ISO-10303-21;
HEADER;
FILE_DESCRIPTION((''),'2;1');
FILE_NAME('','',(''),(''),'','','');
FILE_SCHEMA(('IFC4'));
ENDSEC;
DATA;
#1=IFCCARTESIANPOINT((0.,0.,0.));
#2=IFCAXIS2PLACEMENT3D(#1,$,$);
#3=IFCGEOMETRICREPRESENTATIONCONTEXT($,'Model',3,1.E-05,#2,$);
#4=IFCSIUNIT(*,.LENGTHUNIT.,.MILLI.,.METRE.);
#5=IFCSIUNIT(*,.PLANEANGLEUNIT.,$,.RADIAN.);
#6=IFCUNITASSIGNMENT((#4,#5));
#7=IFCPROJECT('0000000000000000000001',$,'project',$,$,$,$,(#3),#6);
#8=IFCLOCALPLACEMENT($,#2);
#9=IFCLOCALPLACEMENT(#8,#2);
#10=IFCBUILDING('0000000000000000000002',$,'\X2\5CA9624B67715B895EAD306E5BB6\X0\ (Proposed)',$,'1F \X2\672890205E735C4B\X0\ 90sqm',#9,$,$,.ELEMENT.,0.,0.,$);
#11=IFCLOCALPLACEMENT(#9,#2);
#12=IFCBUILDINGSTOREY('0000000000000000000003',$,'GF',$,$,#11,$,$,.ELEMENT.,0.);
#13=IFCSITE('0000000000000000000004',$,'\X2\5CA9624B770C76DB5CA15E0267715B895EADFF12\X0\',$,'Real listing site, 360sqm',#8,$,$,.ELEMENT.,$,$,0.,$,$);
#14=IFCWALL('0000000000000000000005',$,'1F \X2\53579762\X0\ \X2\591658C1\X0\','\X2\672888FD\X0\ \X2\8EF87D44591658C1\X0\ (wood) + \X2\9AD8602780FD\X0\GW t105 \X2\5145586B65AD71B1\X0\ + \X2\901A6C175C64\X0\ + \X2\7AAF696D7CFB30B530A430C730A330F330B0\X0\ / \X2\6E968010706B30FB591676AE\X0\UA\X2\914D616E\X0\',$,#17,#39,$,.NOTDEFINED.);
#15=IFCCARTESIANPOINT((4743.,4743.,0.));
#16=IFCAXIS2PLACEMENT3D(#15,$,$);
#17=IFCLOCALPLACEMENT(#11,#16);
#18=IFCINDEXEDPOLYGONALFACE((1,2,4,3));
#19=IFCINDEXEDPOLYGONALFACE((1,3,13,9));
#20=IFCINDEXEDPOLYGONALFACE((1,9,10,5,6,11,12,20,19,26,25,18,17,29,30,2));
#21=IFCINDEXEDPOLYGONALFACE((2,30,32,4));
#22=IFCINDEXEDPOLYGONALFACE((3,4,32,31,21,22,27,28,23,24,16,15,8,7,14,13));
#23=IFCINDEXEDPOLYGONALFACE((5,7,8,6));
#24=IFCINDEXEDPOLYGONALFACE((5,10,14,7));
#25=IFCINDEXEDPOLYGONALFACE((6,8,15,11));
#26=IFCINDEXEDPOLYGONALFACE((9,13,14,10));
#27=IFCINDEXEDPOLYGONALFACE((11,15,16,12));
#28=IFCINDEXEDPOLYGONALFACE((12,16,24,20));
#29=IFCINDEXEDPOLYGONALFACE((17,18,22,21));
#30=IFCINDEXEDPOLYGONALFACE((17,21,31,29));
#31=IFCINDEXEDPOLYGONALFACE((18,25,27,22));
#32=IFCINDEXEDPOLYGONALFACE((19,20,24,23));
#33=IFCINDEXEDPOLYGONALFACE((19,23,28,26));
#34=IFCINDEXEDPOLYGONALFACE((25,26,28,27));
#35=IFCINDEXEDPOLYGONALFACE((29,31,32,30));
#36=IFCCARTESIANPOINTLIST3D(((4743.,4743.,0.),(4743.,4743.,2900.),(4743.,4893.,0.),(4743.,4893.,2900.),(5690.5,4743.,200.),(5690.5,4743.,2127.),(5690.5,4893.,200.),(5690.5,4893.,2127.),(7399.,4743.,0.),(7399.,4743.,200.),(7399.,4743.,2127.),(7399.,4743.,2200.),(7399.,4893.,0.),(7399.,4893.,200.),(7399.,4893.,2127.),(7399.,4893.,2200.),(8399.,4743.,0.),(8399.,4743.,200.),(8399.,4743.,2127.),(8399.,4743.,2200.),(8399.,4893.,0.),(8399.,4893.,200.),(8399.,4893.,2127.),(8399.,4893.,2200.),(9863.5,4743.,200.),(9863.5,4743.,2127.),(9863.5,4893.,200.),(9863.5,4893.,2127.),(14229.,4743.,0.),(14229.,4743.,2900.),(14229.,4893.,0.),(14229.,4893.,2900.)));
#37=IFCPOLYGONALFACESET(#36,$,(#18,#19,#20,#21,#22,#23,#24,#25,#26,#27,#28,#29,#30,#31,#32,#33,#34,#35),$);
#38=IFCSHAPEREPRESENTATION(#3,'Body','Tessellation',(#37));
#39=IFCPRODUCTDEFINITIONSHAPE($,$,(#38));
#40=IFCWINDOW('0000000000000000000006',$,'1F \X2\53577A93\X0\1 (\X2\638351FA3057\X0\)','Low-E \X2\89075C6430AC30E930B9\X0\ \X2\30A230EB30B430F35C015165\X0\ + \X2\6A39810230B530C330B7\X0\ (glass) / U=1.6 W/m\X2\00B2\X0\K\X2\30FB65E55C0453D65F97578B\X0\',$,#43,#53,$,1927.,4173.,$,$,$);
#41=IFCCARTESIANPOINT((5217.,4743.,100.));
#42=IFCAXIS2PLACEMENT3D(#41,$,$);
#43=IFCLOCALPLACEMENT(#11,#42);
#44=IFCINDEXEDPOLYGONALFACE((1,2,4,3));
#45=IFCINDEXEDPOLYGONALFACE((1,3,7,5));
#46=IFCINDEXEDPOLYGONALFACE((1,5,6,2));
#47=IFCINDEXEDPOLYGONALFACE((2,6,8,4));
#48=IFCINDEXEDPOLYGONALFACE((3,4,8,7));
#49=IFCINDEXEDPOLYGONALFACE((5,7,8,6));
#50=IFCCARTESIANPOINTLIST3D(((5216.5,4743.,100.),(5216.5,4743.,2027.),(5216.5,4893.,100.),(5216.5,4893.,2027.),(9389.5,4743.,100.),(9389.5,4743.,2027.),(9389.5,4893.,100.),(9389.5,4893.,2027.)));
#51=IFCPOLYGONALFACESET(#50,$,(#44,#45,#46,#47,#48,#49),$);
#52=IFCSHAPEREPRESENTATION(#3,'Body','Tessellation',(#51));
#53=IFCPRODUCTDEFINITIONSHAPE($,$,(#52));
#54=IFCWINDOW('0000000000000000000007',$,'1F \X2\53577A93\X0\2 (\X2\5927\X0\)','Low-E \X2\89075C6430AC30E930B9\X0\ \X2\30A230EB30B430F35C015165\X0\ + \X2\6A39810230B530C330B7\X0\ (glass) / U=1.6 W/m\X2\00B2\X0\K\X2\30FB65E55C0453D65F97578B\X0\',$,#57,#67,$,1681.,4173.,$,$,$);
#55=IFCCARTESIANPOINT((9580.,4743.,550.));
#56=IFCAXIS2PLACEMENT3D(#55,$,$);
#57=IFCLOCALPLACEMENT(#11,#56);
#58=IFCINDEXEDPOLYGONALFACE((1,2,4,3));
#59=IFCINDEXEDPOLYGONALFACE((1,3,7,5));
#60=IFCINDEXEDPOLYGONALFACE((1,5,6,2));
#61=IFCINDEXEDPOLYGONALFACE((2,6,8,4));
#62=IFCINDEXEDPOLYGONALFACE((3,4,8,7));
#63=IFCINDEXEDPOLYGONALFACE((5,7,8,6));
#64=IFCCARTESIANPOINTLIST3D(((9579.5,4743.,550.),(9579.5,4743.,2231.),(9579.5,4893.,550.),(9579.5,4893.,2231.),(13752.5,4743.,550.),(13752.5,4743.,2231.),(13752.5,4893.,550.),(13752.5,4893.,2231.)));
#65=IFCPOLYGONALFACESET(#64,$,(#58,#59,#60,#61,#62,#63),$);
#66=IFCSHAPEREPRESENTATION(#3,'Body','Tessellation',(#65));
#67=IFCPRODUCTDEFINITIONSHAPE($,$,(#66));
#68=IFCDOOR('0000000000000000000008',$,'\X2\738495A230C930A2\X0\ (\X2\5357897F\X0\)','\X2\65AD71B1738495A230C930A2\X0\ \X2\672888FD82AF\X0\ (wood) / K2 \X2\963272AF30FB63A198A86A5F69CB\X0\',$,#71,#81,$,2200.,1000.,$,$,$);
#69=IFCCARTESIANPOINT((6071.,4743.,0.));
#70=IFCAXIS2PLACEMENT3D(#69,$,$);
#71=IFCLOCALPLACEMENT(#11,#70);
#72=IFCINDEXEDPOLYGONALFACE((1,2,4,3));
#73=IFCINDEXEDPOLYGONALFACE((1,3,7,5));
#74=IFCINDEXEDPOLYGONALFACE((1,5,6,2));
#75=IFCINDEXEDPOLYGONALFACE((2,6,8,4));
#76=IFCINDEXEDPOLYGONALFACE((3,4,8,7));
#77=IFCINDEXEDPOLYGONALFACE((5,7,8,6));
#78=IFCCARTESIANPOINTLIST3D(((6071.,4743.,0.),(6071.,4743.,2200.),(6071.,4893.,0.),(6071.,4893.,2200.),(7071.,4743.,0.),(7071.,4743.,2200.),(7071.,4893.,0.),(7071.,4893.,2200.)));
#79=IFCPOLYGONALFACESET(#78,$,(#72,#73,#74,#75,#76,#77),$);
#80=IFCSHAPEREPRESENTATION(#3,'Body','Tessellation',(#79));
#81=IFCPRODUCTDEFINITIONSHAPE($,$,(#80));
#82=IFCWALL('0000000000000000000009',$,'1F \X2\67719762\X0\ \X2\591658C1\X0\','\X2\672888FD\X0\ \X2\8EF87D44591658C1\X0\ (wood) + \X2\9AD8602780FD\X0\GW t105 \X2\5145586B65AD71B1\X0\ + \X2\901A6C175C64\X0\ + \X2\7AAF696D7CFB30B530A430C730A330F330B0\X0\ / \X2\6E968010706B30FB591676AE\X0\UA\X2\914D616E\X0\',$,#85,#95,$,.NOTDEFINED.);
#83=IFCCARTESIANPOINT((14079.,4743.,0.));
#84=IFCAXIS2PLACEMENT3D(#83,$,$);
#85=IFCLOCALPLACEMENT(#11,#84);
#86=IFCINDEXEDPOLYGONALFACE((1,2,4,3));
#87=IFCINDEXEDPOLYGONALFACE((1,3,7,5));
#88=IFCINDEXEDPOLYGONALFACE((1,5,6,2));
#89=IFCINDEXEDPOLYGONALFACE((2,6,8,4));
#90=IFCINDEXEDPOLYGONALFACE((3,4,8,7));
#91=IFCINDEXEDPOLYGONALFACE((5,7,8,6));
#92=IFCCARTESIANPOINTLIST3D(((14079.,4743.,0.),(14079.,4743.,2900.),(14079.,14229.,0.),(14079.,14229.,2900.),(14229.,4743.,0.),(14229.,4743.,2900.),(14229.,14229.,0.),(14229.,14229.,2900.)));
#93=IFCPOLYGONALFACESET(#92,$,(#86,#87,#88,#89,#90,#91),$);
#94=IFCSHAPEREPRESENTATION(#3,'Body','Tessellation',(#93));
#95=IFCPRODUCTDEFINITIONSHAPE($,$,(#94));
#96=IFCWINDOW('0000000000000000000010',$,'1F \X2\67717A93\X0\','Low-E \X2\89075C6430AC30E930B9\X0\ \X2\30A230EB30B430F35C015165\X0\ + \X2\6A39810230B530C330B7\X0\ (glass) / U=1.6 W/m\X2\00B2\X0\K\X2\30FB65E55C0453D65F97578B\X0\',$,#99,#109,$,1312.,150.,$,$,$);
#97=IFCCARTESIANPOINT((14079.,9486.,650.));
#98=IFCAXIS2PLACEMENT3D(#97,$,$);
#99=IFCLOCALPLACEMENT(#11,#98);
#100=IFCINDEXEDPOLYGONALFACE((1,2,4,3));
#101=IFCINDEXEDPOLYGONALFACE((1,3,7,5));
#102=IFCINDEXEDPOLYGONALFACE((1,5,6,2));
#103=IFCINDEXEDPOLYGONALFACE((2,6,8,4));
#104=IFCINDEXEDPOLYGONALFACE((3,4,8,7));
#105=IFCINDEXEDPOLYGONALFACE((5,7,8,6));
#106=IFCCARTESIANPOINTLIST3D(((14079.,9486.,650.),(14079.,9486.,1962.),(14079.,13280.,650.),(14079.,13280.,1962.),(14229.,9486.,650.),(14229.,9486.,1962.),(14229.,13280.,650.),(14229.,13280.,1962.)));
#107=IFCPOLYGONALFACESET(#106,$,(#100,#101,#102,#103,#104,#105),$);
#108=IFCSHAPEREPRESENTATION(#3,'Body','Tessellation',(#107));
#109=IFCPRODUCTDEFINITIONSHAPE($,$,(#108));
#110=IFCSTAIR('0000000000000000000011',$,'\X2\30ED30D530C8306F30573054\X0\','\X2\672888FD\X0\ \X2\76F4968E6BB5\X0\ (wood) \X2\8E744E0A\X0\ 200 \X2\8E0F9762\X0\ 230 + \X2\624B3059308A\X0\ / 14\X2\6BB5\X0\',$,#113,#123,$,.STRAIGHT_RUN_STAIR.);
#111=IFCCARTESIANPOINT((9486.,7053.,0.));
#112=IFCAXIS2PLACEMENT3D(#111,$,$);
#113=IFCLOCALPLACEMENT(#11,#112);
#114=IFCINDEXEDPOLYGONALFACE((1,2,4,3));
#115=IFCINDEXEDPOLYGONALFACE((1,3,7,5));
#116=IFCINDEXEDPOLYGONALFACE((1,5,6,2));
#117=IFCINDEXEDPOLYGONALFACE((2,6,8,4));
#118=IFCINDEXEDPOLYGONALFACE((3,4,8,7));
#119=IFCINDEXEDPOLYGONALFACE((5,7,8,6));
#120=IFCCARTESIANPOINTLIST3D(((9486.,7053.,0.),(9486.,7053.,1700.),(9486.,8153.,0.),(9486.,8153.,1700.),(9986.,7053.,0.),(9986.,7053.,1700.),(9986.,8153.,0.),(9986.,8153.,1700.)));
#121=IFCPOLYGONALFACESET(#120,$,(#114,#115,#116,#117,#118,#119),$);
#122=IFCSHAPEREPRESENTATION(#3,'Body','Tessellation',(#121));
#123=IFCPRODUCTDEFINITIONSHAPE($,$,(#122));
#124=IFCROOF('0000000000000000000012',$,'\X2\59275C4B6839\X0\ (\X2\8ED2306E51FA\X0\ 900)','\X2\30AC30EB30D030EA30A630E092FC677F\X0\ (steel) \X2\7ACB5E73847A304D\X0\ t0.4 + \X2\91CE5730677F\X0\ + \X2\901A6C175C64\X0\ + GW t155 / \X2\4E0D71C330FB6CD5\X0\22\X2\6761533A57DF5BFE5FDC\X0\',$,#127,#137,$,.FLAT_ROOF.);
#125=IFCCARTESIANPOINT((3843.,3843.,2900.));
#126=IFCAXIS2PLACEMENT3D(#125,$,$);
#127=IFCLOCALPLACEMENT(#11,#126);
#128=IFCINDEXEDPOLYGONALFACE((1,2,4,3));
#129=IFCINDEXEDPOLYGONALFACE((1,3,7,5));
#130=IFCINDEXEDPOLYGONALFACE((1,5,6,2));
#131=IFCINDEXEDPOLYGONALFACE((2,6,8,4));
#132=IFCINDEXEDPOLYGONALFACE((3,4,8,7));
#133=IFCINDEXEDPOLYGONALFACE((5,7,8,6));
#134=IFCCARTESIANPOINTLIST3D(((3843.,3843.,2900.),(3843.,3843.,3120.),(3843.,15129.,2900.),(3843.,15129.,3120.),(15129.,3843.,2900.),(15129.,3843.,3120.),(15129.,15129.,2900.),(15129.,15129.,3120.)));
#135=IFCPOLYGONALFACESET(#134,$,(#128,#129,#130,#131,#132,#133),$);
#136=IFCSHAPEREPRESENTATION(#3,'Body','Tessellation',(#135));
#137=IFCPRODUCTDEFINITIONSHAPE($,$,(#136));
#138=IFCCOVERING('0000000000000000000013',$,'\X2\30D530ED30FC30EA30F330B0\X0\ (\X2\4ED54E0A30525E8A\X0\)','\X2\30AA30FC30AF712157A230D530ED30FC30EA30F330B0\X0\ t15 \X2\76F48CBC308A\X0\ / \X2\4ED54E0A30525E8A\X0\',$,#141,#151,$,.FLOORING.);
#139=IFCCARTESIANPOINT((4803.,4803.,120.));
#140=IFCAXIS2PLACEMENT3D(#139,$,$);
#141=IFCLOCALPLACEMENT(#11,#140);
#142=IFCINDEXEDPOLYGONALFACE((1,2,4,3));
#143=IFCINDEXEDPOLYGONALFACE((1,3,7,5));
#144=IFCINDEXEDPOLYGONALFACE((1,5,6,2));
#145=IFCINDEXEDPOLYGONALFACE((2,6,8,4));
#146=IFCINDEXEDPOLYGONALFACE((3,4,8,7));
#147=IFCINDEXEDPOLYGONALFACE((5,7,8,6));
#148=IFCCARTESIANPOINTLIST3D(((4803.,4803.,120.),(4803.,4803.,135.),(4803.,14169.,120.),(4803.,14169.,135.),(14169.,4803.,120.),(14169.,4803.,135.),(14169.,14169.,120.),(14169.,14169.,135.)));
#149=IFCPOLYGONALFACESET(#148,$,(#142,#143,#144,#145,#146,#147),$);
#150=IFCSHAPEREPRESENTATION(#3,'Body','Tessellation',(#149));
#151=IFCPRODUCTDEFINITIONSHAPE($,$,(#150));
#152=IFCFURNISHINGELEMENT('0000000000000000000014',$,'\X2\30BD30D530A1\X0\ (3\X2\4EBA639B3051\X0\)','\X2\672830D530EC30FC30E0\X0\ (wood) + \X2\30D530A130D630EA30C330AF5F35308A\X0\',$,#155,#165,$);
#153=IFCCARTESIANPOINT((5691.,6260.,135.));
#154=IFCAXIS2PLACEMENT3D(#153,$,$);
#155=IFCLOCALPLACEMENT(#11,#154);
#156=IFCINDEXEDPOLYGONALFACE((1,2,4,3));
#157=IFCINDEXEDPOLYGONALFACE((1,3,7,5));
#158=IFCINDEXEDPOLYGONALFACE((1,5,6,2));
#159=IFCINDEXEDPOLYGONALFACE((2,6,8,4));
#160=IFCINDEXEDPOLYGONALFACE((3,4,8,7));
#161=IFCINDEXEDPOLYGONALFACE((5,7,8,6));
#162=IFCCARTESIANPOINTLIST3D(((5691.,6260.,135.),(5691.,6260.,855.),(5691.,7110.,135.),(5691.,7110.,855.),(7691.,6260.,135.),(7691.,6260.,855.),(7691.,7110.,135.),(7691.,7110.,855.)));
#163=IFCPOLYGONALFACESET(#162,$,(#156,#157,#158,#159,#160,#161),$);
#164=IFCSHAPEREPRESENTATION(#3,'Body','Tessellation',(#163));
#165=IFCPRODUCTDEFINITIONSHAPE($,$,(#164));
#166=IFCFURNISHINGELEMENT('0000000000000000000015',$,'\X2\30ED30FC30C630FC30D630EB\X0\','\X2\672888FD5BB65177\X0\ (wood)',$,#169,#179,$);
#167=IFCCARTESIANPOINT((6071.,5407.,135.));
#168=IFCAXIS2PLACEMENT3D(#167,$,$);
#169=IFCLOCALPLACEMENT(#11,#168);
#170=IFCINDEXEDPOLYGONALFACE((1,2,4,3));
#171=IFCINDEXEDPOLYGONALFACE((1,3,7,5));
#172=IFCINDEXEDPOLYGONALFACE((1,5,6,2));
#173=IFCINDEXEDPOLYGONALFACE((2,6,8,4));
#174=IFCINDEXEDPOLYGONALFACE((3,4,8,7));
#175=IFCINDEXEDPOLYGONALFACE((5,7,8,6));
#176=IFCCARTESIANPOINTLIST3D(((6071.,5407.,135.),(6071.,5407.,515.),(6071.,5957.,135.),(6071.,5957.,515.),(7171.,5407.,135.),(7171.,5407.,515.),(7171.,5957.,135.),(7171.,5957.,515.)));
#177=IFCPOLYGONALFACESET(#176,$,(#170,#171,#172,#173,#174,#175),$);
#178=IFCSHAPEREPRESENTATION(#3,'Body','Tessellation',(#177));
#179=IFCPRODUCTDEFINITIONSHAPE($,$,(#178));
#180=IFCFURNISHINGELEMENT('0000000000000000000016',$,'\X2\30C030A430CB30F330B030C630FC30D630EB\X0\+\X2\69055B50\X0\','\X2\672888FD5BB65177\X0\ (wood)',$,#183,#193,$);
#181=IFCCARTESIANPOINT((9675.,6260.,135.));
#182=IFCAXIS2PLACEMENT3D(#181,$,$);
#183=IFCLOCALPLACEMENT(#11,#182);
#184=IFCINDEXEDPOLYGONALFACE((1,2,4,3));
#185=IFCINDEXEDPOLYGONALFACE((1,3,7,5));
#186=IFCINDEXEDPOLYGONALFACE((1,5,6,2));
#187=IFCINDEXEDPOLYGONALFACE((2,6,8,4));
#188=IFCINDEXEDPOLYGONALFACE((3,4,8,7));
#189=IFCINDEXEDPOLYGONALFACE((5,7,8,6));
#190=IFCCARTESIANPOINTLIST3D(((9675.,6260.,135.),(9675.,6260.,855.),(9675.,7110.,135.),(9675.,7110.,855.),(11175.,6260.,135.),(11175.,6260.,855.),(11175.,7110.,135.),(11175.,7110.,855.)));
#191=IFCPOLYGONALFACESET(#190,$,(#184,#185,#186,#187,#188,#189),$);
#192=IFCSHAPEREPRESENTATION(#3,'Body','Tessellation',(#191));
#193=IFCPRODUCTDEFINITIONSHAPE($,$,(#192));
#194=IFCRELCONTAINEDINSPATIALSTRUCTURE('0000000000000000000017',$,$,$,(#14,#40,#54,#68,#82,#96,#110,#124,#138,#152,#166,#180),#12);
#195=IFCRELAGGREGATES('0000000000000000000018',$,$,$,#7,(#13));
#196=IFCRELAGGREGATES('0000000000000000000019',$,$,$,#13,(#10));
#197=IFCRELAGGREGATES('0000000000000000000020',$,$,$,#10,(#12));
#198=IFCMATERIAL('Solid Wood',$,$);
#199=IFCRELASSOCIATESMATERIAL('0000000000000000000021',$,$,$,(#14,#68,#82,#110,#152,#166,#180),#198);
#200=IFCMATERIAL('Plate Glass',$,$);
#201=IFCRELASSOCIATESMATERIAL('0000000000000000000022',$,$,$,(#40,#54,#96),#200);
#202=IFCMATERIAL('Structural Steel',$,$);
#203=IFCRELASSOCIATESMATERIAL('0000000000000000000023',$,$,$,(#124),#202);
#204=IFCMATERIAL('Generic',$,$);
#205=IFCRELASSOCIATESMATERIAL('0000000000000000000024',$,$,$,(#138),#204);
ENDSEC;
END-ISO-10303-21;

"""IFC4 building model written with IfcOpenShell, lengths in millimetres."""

from ifc_helpers import new_model, si_unit, frame, frame_2d, origin, place, context, project, spatial, rectangle, extrude, material, element, fill, save


model = new_model("IFC4")

# Units and contexts
model_context = context("Model", 3, precision=1e-05, world=origin())
ifc_project = project(units=[si_unit("LENGTHUNIT", "METRE", prefix="MILLI"), si_unit("PLANEANGLEUNIT", "RADIAN")], contexts=[model_context])

# Site, building, storey
site_placement = place(None, origin())
site = spatial("IfcSite", under=ifc_project, at=site_placement, Name="岩手県盛岡市東安庭２", ObjectType="Real listing site, 360sqm", CompositionType="ELEMENT", RefElevation=0.0)
building_placement = place(site_placement, origin())
building = spatial("IfcBuilding", under=site, at=building_placement, Name="岩手東安庭の家 (Proposed)", ObjectType="1F 木造平屋 90sqm", CompositionType="ELEMENT", ElevationOfRefHeight=0.0, ElevationOfTerrain=0.0)
storey_placement = place(building_placement, origin())
storey = spatial("IfcBuildingStorey", under=building, at=storey_placement, Name="GF", CompositionType="ELEMENT", Elevation=0.0)

# Shared definitions
ifc_material_1 = material(Name="Solid Wood")

# Wall, openings, windows, door
wall_1_placement = place(storey_placement, frame((4743.0, 4743.0, 0.0)))
wall_1 = element("IfcWall", 1, at=wall_1_placement, inside=storey, material=ifc_material_1, Name="1F 南面 外壁", Description="木製 軸組外壁 (wood) + 高性能GW t105 充填断熱 + 通気層 + 窯業系サイディング / 準耐火・外皮UA配慮", PredefinedType="NOTDEFINED", context=model_context, shape_type="SweptSolid", body=[
    extrude(rectangle(XDim=9486.0, YDim=150.0, at=frame_2d((4743.0, 75.0))), frame((4743.0, 4743.0, 0.0)), (0.0, 0.0, 1.0), 2900.0),
])
opening_1_placement = place(storey_placement, frame((5217.0, 4743.0, 100.0)))
opening_1 = element("IfcOpeningElement", 2, at=opening_1_placement, cuts=wall_1, PredefinedType="NOTDEFINED", context=model_context, shape_type="SweptSolid", body=[
    extrude(rectangle(XDim=4173.0, YDim=150.0, at=frame_2d((2086.0, 75.0))), frame((5217.0, 4743.0, 100.0)), (0.0, 0.0, 1.0), 1927.0),
])
opening_2_placement = place(storey_placement, frame((9580.0, 4743.0, 550.0)))
opening_2 = element("IfcOpeningElement", 3, at=opening_2_placement, cuts=wall_1, PredefinedType="NOTDEFINED", context=model_context, shape_type="SweptSolid", body=[
    extrude(rectangle(XDim=4173.0, YDim=150.0, at=frame_2d((2086.0, 75.0))), frame((9580.0, 4743.0, 550.0)), (0.0, 0.0, 1.0), 1681.0),
])
opening_3_placement = place(storey_placement, frame((6071.0, 4743.0, 0.0)))
opening_3 = element("IfcOpeningElement", 4, at=opening_3_placement, cuts=wall_1, PredefinedType="NOTDEFINED", context=model_context, shape_type="SweptSolid", body=[
    extrude(rectangle(XDim=1000.0, YDim=150.0, at=frame_2d((500.0, 75.0))), frame((6071.0, 4743.0, 0.0)), (0.0, 0.0, 1.0), 2200.0),
])
ifc_material_2 = material(Name="Plate Glass")
window_1_placement = place(storey_placement, frame((5217.0, 4743.0, 100.0)))
window_1 = element("IfcWindow", 5, at=window_1_placement, inside=storey, material=ifc_material_2, Name="1F 南窓1 (掃出し)", Description="Low-E 複層ガラス アルゴン封入 + 樹脂サッシ (glass) / U=1.6 W/m²K・日射取得型", OverallHeight=1927.0, OverallWidth=4173.0, context=model_context, shape_type="SweptSolid", body=[
    extrude(rectangle(XDim=4173.0, YDim=150.0, at=frame_2d((2086.0, 75.0))), frame((5217.0, 4743.0, 100.0)), (0.0, 0.0, 1.0), 1927.0),
])
fill(opening_1, window_1)
window_2_placement = place(storey_placement, frame((9580.0, 4743.0, 550.0)))
window_2 = element("IfcWindow", 6, at=window_2_placement, inside=storey, material=ifc_material_2, Name="1F 南窓2 (大)", Description="Low-E 複層ガラス アルゴン封入 + 樹脂サッシ (glass) / U=1.6 W/m²K・日射取得型", OverallHeight=1681.0, OverallWidth=4173.0, context=model_context, shape_type="SweptSolid", body=[
    extrude(rectangle(XDim=4173.0, YDim=150.0, at=frame_2d((2086.0, 75.0))), frame((9580.0, 4743.0, 550.0)), (0.0, 0.0, 1.0), 1681.0),
])
fill(opening_2, window_2)
door_placement = place(storey_placement, frame((6071.0, 4743.0, 0.0)))
door = element("IfcDoor", 7, at=door_placement, inside=storey, material=ifc_material_1, Name="玄関ドア (南西)", Description="断熱玄関ドア 木製芯 (wood) / K2 防犯・採風機構", OverallHeight=2200.0, OverallWidth=1000.0, context=model_context, shape_type="SweptSolid", body=[
    extrude(rectangle(XDim=1000.0, YDim=150.0, at=frame_2d((500.0, 75.0))), frame((6071.0, 4743.0, 0.0)), (0.0, 0.0, 1.0), 2200.0),
])
fill(opening_3, door)

# Wall, opening, window
wall_2_placement = place(storey_placement, frame((14079.0, 4743.0, 0.0)))
wall_2 = element("IfcWall", 8, at=wall_2_placement, inside=storey, material=ifc_material_1, Name="1F 東面 外壁", Description="木製 軸組外壁 (wood) + 高性能GW t105 充填断熱 + 通気層 + 窯業系サイディング / 準耐火・外皮UA配慮", PredefinedType="NOTDEFINED", context=model_context, shape_type="SweptSolid", body=[
    extrude(rectangle(XDim=150.0, YDim=9486.0, at=frame_2d((75.0, 4743.0))), frame((14079.0, 4743.0, 0.0)), (0.0, 0.0, 1.0), 2900.0),
])
opening_4_placement = place(storey_placement, frame((14079.0, 9486.0, 650.0)))
opening_4 = element("IfcOpeningElement", 9, at=opening_4_placement, cuts=wall_2, PredefinedType="NOTDEFINED", context=model_context, shape_type="SweptSolid", body=[
    extrude(rectangle(XDim=150.0, YDim=3794.0, at=frame_2d((75.0, 1897.0))), frame((14079.0, 9486.0, 650.0)), (0.0, 0.0, 1.0), 1312.0),
])
window_3_placement = place(storey_placement, frame((14079.0, 9486.0, 650.0)))
window_3 = element("IfcWindow", 10, at=window_3_placement, inside=storey, material=ifc_material_2, Name="1F 東窓", Description="Low-E 複層ガラス アルゴン封入 + 樹脂サッシ (glass) / U=1.6 W/m²K・日射取得型", OverallHeight=1312.0, OverallWidth=150.0, context=model_context, shape_type="SweptSolid", body=[
    extrude(rectangle(XDim=150.0, YDim=3794.0, at=frame_2d((75.0, 1897.0))), frame((14079.0, 9486.0, 650.0)), (0.0, 0.0, 1.0), 1312.0),
])
fill(opening_4, window_3)

# Stair
stair_placement = place(storey_placement, frame((9486.0, 7053.0, 0.0)))
element("IfcStair", 11, at=stair_placement, inside=storey, material=ifc_material_1, Name="ロフトはしご", Description="木製 直階段 (wood) 蹴上 200 踏面 230 + 手すり / 14段", PredefinedType="STRAIGHT_RUN_STAIR", context=model_context, shape_type="SweptSolid", body=[
    extrude(rectangle(XDim=500.0, YDim=1100.0, at=frame_2d((250.0, 550.0))), frame((9486.0, 7053.0, 0.0)), (0.0, 0.0, 1.0), 1700.0),
])

# Roof
ifc_material_3 = material(Name="Structural Steel")
roof_placement = place(storey_placement, frame((3843.0, 3843.0, 2900.0)))
element("IfcRoof", 12, at=roof_placement, inside=storey, material=ifc_material_3, Name="大屋根 (軒の出 900)", Description="ガルバリウム鋼板 (steel) 立平葺き t0.4 + 野地板 + 通気層 + GW t155 / 不燃・法22条区域対応", PredefinedType="FLAT_ROOF", context=model_context, shape_type="SweptSolid", body=[
    extrude(rectangle(XDim=11286.0, YDim=11286.0, at=frame_2d((5643.0, 5643.0))), frame((3843.0, 3843.0, 2900.0)), (0.0, 0.0, 1.0), 220.0),
])

# Covering
ifc_material_4 = material(Name="Generic")
covering_placement = place(storey_placement, frame((4803.0, 4803.0, 120.0)))
element("IfcCovering", 13, at=covering_placement, inside=storey, material=ifc_material_4, Name="フローリング (仕上げ床)", Description="オーク無垢フローリング t15 直貼り / 仕上げ床", PredefinedType="FLOORING", context=model_context, shape_type="SweptSolid", body=[
    extrude(rectangle(XDim=9366.0, YDim=9366.0, at=frame_2d((4683.0, 4683.0))), frame((4803.0, 4803.0, 120.0)), (0.0, 0.0, 1.0), 15.0),
])

# Furnishing elements
furnishing_1_placement = place(storey_placement, frame((5691.0, 6260.0, 135.0)))
element("IfcFurnishingElement", 14, at=furnishing_1_placement, inside=storey, material=ifc_material_1, Name="ソファ (3人掛け)", Description="木フレーム (wood) + ファブリック張り", context=model_context, shape_type="SweptSolid", body=[
    extrude(rectangle(XDim=2000.0, YDim=850.0, at=frame_2d((1000.0, 425.0))), frame((5691.0, 6260.0, 135.0)), (0.0, 0.0, 1.0), 720.0),
])
furnishing_2_placement = place(storey_placement, frame((6071.0, 5407.0, 135.0)))
element("IfcFurnishingElement", 15, at=furnishing_2_placement, inside=storey, material=ifc_material_1, Name="ローテーブル", Description="木製家具 (wood)", context=model_context, shape_type="SweptSolid", body=[
    extrude(rectangle(XDim=1100.0, YDim=550.0, at=frame_2d((550.0, 275.0))), frame((6071.0, 5407.0, 135.0)), (0.0, 0.0, 1.0), 380.0),
])
furnishing_3_placement = place(storey_placement, frame((9675.0, 6260.0, 135.0)))
element("IfcFurnishingElement", 16, at=furnishing_3_placement, inside=storey, material=ifc_material_1, Name="ダイニングテーブル+椅子", Description="木製家具 (wood)", context=model_context, shape_type="SweptSolid", body=[
    extrude(rectangle(XDim=1500.0, YDim=850.0, at=frame_2d((750.0, 425.0))), frame((9675.0, 6260.0, 135.0)), (0.0, 0.0, 1.0), 720.0),
])

save(model, "model.ifc")
